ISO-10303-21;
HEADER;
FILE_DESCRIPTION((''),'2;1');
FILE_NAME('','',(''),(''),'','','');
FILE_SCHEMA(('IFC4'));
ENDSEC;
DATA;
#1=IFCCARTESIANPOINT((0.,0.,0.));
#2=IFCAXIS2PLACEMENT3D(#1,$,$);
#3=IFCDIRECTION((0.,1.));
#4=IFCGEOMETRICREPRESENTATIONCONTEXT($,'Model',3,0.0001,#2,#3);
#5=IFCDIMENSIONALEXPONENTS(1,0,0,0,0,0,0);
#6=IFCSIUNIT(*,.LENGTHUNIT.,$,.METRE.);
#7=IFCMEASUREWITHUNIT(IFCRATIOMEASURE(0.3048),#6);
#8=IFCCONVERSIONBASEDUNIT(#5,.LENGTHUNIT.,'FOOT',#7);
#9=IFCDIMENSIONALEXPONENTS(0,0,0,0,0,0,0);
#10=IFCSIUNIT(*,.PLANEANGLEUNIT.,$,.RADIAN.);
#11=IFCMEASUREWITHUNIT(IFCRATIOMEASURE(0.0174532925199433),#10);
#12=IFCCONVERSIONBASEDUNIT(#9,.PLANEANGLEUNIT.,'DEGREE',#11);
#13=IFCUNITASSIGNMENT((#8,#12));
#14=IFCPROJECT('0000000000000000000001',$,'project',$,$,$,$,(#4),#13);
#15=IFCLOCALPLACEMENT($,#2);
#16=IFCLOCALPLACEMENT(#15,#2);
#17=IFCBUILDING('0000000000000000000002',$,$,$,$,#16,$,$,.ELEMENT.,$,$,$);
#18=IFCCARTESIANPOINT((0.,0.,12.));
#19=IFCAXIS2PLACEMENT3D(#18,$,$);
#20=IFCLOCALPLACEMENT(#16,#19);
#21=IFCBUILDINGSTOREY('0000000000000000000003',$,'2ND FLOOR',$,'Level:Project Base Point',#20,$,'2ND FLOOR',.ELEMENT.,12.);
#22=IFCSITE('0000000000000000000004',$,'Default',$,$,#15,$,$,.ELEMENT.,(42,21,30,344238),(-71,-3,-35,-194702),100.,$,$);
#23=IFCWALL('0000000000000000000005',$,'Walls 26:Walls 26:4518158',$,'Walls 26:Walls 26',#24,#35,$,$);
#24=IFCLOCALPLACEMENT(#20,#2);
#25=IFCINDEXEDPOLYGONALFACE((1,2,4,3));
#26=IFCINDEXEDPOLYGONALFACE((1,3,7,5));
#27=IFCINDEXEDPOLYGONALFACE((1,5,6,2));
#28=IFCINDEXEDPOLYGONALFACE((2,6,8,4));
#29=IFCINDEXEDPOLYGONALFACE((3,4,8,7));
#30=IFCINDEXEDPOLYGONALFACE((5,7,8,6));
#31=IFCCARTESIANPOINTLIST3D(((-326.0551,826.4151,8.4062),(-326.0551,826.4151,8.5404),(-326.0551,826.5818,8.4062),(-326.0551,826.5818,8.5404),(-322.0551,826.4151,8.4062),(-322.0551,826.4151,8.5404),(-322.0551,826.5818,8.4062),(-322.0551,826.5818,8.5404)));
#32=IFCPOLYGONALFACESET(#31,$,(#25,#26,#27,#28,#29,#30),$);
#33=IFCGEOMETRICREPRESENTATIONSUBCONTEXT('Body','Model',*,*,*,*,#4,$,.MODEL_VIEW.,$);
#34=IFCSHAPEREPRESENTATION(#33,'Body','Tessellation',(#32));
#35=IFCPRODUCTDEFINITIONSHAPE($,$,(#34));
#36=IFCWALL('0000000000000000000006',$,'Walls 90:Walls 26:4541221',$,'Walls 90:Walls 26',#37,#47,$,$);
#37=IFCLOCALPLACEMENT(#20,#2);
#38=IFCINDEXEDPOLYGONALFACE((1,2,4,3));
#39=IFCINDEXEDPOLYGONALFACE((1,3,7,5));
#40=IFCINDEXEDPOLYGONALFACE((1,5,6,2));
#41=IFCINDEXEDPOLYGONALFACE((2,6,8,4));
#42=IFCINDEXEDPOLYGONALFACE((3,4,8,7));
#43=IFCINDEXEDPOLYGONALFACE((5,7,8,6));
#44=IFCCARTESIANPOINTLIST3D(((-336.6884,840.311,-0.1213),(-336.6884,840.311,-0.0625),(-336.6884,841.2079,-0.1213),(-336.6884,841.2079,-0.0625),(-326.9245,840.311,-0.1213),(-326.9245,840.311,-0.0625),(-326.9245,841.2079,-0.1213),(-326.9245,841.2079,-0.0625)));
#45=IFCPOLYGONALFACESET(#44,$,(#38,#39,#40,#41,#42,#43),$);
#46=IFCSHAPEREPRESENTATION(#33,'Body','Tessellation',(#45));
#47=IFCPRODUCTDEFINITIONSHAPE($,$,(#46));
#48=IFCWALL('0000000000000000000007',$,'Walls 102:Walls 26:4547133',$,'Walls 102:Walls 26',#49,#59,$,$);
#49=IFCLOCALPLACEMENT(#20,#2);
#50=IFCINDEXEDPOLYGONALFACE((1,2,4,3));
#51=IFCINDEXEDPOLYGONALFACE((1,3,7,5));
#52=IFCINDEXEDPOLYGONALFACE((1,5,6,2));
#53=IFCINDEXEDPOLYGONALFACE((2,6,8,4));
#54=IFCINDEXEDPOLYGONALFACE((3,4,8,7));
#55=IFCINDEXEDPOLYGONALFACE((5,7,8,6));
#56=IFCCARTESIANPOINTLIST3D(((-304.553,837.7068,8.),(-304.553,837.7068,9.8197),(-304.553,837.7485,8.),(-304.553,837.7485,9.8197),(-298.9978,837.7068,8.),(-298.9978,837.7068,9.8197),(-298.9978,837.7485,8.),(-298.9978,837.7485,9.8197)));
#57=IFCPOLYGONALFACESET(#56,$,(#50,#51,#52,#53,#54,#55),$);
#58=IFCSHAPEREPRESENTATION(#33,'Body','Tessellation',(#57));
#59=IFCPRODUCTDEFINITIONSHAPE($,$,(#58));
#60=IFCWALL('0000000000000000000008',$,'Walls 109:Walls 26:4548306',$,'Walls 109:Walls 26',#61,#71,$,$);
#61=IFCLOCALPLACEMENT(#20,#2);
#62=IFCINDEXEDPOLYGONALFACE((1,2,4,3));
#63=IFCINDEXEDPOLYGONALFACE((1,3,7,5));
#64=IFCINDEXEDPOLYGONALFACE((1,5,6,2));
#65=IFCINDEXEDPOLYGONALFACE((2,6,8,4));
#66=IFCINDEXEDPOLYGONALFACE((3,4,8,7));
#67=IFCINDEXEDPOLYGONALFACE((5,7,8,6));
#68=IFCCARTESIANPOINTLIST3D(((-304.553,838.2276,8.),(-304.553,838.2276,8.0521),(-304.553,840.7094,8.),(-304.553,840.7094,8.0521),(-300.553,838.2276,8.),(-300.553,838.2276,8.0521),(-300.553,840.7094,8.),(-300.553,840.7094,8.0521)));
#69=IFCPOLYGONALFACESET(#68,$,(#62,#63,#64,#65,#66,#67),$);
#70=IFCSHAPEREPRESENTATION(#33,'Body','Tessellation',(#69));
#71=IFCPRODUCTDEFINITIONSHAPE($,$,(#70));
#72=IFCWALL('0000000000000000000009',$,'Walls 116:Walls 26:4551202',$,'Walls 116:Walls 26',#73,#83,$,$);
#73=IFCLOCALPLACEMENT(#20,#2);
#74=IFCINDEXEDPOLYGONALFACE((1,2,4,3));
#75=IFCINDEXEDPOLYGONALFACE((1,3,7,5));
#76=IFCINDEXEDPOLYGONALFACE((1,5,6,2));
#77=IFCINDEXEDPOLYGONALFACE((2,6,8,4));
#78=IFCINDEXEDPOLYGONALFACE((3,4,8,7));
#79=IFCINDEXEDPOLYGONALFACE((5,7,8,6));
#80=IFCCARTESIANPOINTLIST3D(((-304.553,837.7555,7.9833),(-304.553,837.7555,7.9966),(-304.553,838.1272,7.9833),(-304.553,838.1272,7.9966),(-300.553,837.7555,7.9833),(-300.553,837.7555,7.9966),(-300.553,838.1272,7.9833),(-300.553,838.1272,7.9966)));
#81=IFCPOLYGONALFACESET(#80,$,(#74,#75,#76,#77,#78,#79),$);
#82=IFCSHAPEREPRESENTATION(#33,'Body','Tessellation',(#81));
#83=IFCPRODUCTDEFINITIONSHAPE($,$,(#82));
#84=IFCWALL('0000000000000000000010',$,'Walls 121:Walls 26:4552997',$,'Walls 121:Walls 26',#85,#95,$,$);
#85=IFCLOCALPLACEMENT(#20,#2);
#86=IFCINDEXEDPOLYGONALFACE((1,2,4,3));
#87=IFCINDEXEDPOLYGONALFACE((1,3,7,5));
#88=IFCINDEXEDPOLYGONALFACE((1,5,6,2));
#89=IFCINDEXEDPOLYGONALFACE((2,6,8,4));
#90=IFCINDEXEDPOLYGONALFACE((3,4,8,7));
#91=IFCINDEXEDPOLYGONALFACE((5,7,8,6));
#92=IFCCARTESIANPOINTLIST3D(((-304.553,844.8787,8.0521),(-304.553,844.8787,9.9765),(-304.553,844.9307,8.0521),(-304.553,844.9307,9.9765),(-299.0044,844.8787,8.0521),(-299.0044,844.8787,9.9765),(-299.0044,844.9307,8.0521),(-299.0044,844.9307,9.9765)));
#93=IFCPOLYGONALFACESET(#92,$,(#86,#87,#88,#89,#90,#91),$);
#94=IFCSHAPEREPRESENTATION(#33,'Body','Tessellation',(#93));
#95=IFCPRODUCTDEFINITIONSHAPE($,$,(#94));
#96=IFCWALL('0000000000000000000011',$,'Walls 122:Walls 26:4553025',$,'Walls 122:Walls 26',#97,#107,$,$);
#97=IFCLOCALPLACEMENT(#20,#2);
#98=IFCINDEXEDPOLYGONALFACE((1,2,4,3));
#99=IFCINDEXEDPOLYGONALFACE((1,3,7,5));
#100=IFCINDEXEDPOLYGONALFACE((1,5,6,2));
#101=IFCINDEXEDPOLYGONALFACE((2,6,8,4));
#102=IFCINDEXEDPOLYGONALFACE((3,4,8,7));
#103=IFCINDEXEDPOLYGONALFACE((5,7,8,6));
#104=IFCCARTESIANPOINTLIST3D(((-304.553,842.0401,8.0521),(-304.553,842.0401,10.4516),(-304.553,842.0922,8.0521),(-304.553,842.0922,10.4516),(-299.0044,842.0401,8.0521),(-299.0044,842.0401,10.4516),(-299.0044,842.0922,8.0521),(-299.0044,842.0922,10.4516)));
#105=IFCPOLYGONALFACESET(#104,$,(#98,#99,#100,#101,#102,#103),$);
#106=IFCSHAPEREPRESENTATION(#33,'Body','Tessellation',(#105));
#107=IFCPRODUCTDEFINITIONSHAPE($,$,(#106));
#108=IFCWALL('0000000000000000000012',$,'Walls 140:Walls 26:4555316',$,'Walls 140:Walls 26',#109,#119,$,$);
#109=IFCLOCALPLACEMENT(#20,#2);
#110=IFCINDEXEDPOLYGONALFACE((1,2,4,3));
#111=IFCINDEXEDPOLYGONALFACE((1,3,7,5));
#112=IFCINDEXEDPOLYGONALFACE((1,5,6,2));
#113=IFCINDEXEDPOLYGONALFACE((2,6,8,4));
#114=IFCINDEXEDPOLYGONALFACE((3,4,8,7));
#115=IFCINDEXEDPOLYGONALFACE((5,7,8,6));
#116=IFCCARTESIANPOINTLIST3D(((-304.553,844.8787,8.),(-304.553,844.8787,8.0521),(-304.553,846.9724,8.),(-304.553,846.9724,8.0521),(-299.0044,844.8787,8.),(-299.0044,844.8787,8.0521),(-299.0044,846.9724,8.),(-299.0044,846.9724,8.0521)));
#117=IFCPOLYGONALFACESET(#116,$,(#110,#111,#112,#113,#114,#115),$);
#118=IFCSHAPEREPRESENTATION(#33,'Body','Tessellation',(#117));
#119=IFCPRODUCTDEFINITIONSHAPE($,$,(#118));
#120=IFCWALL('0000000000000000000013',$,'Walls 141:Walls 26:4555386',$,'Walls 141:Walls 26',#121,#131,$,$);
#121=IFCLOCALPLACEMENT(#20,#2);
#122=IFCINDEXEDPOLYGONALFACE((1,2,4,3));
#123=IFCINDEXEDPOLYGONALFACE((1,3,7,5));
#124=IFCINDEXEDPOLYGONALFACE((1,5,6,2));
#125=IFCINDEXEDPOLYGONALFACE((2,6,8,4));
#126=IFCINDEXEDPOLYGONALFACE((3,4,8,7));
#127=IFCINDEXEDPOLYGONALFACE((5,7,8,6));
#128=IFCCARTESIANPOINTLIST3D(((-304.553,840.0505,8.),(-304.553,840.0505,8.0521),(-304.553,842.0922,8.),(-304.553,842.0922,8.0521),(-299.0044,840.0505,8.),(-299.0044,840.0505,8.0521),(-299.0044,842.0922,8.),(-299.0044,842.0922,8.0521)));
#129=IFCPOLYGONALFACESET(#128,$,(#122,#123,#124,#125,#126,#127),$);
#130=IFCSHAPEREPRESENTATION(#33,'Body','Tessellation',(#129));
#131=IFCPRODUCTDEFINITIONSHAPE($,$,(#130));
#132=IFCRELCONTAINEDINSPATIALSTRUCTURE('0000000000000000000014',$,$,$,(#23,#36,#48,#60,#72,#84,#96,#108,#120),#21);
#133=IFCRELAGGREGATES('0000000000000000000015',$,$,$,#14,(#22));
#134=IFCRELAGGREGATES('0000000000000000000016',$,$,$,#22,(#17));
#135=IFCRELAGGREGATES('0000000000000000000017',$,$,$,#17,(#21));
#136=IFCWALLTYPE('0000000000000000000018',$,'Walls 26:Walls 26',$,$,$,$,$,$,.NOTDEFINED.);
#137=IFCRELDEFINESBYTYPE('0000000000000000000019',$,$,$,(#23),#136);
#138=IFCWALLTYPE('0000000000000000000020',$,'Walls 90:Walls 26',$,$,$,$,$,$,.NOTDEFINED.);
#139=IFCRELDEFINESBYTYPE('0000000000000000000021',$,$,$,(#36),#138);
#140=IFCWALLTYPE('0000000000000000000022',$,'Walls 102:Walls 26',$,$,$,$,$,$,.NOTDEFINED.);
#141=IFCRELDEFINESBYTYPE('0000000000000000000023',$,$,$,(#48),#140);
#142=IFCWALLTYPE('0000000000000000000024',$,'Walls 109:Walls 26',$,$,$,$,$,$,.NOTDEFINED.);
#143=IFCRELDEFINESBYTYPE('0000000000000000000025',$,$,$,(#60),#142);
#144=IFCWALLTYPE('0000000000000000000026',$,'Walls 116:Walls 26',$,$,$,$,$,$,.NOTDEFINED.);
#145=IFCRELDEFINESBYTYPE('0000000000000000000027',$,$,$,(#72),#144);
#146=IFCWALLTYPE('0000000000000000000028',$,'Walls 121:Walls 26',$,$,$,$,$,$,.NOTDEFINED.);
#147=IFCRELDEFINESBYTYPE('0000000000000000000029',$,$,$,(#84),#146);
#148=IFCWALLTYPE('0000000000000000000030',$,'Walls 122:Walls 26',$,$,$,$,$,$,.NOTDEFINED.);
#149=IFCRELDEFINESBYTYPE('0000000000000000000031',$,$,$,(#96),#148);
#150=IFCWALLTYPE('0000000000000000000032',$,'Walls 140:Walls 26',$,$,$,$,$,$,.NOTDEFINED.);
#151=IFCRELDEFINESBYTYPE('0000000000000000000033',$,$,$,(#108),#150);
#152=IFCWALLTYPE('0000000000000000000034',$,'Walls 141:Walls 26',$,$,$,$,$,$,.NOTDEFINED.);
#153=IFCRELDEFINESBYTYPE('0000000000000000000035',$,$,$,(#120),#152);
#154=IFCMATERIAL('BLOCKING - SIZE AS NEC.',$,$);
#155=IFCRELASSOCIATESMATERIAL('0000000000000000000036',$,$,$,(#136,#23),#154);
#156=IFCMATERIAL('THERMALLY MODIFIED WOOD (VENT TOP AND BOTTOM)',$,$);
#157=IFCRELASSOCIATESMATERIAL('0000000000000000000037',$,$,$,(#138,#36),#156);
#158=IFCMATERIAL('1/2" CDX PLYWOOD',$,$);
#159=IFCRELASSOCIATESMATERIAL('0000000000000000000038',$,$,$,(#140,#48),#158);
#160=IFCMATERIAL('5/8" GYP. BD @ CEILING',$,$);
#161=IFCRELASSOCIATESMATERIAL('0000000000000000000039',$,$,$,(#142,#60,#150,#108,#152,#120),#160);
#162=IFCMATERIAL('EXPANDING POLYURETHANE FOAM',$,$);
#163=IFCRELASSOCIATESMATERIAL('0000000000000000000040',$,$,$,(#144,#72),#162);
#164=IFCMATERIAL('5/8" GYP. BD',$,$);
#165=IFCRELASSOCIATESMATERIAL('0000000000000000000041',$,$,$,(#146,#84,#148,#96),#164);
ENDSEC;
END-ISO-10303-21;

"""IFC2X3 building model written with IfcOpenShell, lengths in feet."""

from ifc_helpers import new_model, entity, si_unit, converted_unit, direction, frame, frame_2d, origin, origin_2d_with_axis, place, context, subcontext, project, spatial, rectangle, extrude, material, type_object, element, save


model = new_model("IFC2X3")

# Units and contexts
model_context = context("Model", 3, precision=0.0001, world=origin(), true_north=direction((0.0, 1.0)))
body_context = subcontext(model_context, "Body", "Model", "MODEL_VIEW")
ifc_project = project(units=[converted_unit("LENGTHUNIT", "FOOT", entity("IfcRatioMeasure", 0.3048), si_unit("LENGTHUNIT", "METRE"), dimensions=[1, 0, 0, 0, 0, 0, 0]), converted_unit("PLANEANGLEUNIT", "DEGREE", entity("IfcRatioMeasure", 0.0174532925199433), si_unit("PLANEANGLEUNIT", "RADIAN"), dimensions=[0, 0, 0, 0, 0, 0, 0])], contexts=[model_context])

# Site, building, storey
site_placement = place(None, origin())
site = spatial("IfcSite", under=ifc_project, at=site_placement, Name="Default", CompositionType="ELEMENT", RefLatitude=(42, 21, 30, 344238), RefLongitude=(-71, -3, -35, -194702), RefElevation=100.0)
building_placement = place(site_placement, origin())
building = spatial("IfcBuilding", under=site, at=building_placement, CompositionType="ELEMENT")
storey_placement = place(building_placement, frame((0.0, 0.0, 12.0)))
storey = spatial("IfcBuildingStorey", under=building, at=storey_placement, Name="2ND FLOOR", ObjectType="Level:Project Base Point", LongName="2ND FLOOR", CompositionType="ELEMENT", Elevation=12.0)

# Walls
ifc_material_1 = material(Name="5/8\" GYP. BD")
ifc_material_2 = material(Name="1/2\" CDX PLYWOOD")
ifc_material_3 = material(Name="EXPANDING POLYURETHANE FOAM")
ifc_material_4 = material(Name="BLOCKING - SIZE AS NEC.")
wall_type_1 = type_object("IfcWallType", Name="Walls 26:Walls 26", PredefinedType="NOTDEFINED", material=ifc_material_4)
wall_1_placement = place(storey_placement, frame((-326.0551, 826.4151, 8.4062)))
element("IfcWall", 1, at=wall_1_placement, inside=storey, type_object=wall_type_1, material=ifc_material_4, Name="Walls 26:Walls 26:4518158", ObjectType="Walls 26:Walls 26", context=body_context, shape_type="SweptSolid", body=[
    extrude(rectangle(XDim=4.0, YDim=0.1667, at=origin_2d_with_axis()), frame((2.0, 0.0833, 0.0), z_axis=(0.0, 0.0, 1.0), x_axis=(-1.0, 0.0, 0.0)), (0.0, 0.0, 1.0), 0.1341),
])
ifc_material_5 = material(Name="THERMALLY MODIFIED WOOD (VENT TOP AND BOTTOM)")
wall_type_2 = type_object("IfcWallType", Name="Walls 90:Walls 26", PredefinedType="NOTDEFINED", material=ifc_material_5)
wall_2_placement = place(storey_placement, frame((-336.6884, 840.311, -0.1213)))
element("IfcWall", 2, at=wall_2_placement, inside=storey, type_object=wall_type_2, material=ifc_material_5, Name="Walls 90:Walls 26:4541221", ObjectType="Walls 90:Walls 26", context=body_context, shape_type="SweptSolid", body=[
    extrude(rectangle(XDim=9.7639, YDim=0.897, at=origin_2d_with_axis()), frame((4.882, 0.4485, 0.0), z_axis=(0.0, 0.0, 1.0), x_axis=(-1.0, 0.0, 0.0)), (0.0, 0.0, 1.0), 0.0588),
])
wall_type_3 = type_object("IfcWallType", Name="Walls 102:Walls 26", PredefinedType="NOTDEFINED", material=ifc_material_2)
wall_3_placement = place(storey_placement, frame((-304.553, 837.7068, 8.0)))
element("IfcWall", 3, at=wall_3_placement, inside=storey, type_object=wall_type_3, material=ifc_material_2, Name="Walls 102:Walls 26:4547133", ObjectType="Walls 102:Walls 26", context=body_context, shape_type="SweptSolid", body=[
    extrude(rectangle(XDim=5.5551, YDim=0.0417, at=frame_2d((0.0, 0.0), x_axis=(1.0, 0.0))), frame((2.7776, 0.0208, 0.0), z_axis=(0.0, 0.0, 1.0), x_axis=(-1.0, 0.0, 0.0)), (0.0, 0.0, 1.0), 1.8197),
])
ifc_material_6 = material(Name="5/8\" GYP. BD @ CEILING")
wall_type_4 = type_object("IfcWallType", Name="Walls 109:Walls 26", PredefinedType="NOTDEFINED", material=ifc_material_6)
wall_4_placement = place(storey_placement, frame((-304.553, 838.2276, 8.0)))
element("IfcWall", 4, at=wall_4_placement, inside=storey, type_object=wall_type_4, material=ifc_material_6, Name="Walls 109:Walls 26:4548306", ObjectType="Walls 109:Walls 26", context=body_context, shape_type="SweptSolid", body=[
    extrude(rectangle(XDim=4.0, YDim=2.4818, at=frame_2d((0.0, 0.0), x_axis=(1.0, 0.0))), frame((2.0, 1.2409, 0.0), z_axis=(0.0, 0.0, 1.0), x_axis=(-1.0, 0.0, 0.0)), (0.0, 0.0, 1.0), 0.0521),
])
wall_type_5 = type_object("IfcWallType", Name="Walls 116:Walls 26", PredefinedType="NOTDEFINED", material=ifc_material_3)
wall_5_placement = place(storey_placement, frame((-304.553, 837.7555, 7.9833)))
element("IfcWall", 5, at=wall_5_placement, inside=storey, type_object=wall_type_5, material=ifc_material_3, Name="Walls 116:Walls 26:4551202", ObjectType="Walls 116:Walls 26", context=body_context, shape_type="SweptSolid", body=[
    extrude(rectangle(XDim=4.0, YDim=0.3717, at=origin_2d_with_axis()), frame((2.0, 0.1858, 0.0), z_axis=(0.0, 0.0, 1.0), x_axis=(-1.0, 0.0, 0.0)), (0.0, 0.0, 1.0), 0.0133),
])
wall_type_6 = type_object("IfcWallType", Name="Walls 121:Walls 26", PredefinedType="NOTDEFINED", material=ifc_material_1)
wall_6_placement = place(storey_placement, frame((-304.553, 844.8787, 8.0521)))
element("IfcWall", 6, at=wall_6_placement, inside=storey, type_object=wall_type_6, material=ifc_material_1, Name="Walls 121:Walls 26:4552997", ObjectType="Walls 121:Walls 26", context=body_context, shape_type="SweptSolid", body=[
    extrude(rectangle(XDim=5.5486, YDim=0.0521, at=frame_2d((0.0, 0.0), x_axis=(1.0, 0.0))), frame((2.7743, 0.026, 0.0), z_axis=(0.0, 0.0, 1.0), x_axis=(-1.0, 0.0, 0.0)), (0.0, 0.0, 1.0), 1.9244),
])
wall_type_7 = type_object("IfcWallType", Name="Walls 122:Walls 26", PredefinedType="NOTDEFINED", material=ifc_material_1)
wall_7_placement = place(storey_placement, frame((-304.553, 842.0401, 8.0521)))
element("IfcWall", 7, at=wall_7_placement, inside=storey, type_object=wall_type_7, material=ifc_material_1, Name="Walls 122:Walls 26:4553025", ObjectType="Walls 122:Walls 26", context=body_context, shape_type="SweptSolid", body=[
    extrude(rectangle(XDim=5.5486, YDim=0.0521, at=frame_2d((0.0, 0.0), x_axis=(1.0, 0.0))), frame((2.7743, 0.026, 0.0), z_axis=(0.0, 0.0, 1.0), x_axis=(-1.0, 0.0, 0.0)), (0.0, 0.0, 1.0), 2.3995),
])
wall_type_8 = type_object("IfcWallType", Name="Walls 140:Walls 26", PredefinedType="NOTDEFINED", material=ifc_material_6)
wall_8_placement = place(storey_placement, frame((-304.553, 844.8787, 8.0)))
element("IfcWall", 8, at=wall_8_placement, inside=storey, type_object=wall_type_8, material=ifc_material_6, Name="Walls 140:Walls 26:4555316", ObjectType="Walls 140:Walls 26", context=body_context, shape_type="SweptSolid", body=[
    extrude(rectangle(XDim=5.5486, YDim=2.0938, at=origin_2d_with_axis()), frame((2.7743, 1.0469, 0.0), z_axis=(0.0, 0.0, 1.0), x_axis=(-1.0, 0.0, 0.0)), (0.0, 0.0, 1.0), 0.0521),
])
wall_type_9 = type_object("IfcWallType", Name="Walls 141:Walls 26", PredefinedType="NOTDEFINED", material=ifc_material_6)
wall_9_placement = place(storey_placement, frame((-304.553, 840.0505, 8.0)))
element("IfcWall", 9, at=wall_9_placement, inside=storey, type_object=wall_type_9, material=ifc_material_6, Name="Walls 141:Walls 26:4555386", ObjectType="Walls 141:Walls 26", context=body_context, shape_type="SweptSolid", body=[
    extrude(rectangle(XDim=5.5486, YDim=2.0417, at=origin_2d_with_axis()), frame((2.7743, 1.0208, 0.0), z_axis=(0.0, 0.0, 1.0), x_axis=(-1.0, 0.0, 0.0)), (0.0, 0.0, 1.0), 0.0521),
])

save(model, "model.ifc")
